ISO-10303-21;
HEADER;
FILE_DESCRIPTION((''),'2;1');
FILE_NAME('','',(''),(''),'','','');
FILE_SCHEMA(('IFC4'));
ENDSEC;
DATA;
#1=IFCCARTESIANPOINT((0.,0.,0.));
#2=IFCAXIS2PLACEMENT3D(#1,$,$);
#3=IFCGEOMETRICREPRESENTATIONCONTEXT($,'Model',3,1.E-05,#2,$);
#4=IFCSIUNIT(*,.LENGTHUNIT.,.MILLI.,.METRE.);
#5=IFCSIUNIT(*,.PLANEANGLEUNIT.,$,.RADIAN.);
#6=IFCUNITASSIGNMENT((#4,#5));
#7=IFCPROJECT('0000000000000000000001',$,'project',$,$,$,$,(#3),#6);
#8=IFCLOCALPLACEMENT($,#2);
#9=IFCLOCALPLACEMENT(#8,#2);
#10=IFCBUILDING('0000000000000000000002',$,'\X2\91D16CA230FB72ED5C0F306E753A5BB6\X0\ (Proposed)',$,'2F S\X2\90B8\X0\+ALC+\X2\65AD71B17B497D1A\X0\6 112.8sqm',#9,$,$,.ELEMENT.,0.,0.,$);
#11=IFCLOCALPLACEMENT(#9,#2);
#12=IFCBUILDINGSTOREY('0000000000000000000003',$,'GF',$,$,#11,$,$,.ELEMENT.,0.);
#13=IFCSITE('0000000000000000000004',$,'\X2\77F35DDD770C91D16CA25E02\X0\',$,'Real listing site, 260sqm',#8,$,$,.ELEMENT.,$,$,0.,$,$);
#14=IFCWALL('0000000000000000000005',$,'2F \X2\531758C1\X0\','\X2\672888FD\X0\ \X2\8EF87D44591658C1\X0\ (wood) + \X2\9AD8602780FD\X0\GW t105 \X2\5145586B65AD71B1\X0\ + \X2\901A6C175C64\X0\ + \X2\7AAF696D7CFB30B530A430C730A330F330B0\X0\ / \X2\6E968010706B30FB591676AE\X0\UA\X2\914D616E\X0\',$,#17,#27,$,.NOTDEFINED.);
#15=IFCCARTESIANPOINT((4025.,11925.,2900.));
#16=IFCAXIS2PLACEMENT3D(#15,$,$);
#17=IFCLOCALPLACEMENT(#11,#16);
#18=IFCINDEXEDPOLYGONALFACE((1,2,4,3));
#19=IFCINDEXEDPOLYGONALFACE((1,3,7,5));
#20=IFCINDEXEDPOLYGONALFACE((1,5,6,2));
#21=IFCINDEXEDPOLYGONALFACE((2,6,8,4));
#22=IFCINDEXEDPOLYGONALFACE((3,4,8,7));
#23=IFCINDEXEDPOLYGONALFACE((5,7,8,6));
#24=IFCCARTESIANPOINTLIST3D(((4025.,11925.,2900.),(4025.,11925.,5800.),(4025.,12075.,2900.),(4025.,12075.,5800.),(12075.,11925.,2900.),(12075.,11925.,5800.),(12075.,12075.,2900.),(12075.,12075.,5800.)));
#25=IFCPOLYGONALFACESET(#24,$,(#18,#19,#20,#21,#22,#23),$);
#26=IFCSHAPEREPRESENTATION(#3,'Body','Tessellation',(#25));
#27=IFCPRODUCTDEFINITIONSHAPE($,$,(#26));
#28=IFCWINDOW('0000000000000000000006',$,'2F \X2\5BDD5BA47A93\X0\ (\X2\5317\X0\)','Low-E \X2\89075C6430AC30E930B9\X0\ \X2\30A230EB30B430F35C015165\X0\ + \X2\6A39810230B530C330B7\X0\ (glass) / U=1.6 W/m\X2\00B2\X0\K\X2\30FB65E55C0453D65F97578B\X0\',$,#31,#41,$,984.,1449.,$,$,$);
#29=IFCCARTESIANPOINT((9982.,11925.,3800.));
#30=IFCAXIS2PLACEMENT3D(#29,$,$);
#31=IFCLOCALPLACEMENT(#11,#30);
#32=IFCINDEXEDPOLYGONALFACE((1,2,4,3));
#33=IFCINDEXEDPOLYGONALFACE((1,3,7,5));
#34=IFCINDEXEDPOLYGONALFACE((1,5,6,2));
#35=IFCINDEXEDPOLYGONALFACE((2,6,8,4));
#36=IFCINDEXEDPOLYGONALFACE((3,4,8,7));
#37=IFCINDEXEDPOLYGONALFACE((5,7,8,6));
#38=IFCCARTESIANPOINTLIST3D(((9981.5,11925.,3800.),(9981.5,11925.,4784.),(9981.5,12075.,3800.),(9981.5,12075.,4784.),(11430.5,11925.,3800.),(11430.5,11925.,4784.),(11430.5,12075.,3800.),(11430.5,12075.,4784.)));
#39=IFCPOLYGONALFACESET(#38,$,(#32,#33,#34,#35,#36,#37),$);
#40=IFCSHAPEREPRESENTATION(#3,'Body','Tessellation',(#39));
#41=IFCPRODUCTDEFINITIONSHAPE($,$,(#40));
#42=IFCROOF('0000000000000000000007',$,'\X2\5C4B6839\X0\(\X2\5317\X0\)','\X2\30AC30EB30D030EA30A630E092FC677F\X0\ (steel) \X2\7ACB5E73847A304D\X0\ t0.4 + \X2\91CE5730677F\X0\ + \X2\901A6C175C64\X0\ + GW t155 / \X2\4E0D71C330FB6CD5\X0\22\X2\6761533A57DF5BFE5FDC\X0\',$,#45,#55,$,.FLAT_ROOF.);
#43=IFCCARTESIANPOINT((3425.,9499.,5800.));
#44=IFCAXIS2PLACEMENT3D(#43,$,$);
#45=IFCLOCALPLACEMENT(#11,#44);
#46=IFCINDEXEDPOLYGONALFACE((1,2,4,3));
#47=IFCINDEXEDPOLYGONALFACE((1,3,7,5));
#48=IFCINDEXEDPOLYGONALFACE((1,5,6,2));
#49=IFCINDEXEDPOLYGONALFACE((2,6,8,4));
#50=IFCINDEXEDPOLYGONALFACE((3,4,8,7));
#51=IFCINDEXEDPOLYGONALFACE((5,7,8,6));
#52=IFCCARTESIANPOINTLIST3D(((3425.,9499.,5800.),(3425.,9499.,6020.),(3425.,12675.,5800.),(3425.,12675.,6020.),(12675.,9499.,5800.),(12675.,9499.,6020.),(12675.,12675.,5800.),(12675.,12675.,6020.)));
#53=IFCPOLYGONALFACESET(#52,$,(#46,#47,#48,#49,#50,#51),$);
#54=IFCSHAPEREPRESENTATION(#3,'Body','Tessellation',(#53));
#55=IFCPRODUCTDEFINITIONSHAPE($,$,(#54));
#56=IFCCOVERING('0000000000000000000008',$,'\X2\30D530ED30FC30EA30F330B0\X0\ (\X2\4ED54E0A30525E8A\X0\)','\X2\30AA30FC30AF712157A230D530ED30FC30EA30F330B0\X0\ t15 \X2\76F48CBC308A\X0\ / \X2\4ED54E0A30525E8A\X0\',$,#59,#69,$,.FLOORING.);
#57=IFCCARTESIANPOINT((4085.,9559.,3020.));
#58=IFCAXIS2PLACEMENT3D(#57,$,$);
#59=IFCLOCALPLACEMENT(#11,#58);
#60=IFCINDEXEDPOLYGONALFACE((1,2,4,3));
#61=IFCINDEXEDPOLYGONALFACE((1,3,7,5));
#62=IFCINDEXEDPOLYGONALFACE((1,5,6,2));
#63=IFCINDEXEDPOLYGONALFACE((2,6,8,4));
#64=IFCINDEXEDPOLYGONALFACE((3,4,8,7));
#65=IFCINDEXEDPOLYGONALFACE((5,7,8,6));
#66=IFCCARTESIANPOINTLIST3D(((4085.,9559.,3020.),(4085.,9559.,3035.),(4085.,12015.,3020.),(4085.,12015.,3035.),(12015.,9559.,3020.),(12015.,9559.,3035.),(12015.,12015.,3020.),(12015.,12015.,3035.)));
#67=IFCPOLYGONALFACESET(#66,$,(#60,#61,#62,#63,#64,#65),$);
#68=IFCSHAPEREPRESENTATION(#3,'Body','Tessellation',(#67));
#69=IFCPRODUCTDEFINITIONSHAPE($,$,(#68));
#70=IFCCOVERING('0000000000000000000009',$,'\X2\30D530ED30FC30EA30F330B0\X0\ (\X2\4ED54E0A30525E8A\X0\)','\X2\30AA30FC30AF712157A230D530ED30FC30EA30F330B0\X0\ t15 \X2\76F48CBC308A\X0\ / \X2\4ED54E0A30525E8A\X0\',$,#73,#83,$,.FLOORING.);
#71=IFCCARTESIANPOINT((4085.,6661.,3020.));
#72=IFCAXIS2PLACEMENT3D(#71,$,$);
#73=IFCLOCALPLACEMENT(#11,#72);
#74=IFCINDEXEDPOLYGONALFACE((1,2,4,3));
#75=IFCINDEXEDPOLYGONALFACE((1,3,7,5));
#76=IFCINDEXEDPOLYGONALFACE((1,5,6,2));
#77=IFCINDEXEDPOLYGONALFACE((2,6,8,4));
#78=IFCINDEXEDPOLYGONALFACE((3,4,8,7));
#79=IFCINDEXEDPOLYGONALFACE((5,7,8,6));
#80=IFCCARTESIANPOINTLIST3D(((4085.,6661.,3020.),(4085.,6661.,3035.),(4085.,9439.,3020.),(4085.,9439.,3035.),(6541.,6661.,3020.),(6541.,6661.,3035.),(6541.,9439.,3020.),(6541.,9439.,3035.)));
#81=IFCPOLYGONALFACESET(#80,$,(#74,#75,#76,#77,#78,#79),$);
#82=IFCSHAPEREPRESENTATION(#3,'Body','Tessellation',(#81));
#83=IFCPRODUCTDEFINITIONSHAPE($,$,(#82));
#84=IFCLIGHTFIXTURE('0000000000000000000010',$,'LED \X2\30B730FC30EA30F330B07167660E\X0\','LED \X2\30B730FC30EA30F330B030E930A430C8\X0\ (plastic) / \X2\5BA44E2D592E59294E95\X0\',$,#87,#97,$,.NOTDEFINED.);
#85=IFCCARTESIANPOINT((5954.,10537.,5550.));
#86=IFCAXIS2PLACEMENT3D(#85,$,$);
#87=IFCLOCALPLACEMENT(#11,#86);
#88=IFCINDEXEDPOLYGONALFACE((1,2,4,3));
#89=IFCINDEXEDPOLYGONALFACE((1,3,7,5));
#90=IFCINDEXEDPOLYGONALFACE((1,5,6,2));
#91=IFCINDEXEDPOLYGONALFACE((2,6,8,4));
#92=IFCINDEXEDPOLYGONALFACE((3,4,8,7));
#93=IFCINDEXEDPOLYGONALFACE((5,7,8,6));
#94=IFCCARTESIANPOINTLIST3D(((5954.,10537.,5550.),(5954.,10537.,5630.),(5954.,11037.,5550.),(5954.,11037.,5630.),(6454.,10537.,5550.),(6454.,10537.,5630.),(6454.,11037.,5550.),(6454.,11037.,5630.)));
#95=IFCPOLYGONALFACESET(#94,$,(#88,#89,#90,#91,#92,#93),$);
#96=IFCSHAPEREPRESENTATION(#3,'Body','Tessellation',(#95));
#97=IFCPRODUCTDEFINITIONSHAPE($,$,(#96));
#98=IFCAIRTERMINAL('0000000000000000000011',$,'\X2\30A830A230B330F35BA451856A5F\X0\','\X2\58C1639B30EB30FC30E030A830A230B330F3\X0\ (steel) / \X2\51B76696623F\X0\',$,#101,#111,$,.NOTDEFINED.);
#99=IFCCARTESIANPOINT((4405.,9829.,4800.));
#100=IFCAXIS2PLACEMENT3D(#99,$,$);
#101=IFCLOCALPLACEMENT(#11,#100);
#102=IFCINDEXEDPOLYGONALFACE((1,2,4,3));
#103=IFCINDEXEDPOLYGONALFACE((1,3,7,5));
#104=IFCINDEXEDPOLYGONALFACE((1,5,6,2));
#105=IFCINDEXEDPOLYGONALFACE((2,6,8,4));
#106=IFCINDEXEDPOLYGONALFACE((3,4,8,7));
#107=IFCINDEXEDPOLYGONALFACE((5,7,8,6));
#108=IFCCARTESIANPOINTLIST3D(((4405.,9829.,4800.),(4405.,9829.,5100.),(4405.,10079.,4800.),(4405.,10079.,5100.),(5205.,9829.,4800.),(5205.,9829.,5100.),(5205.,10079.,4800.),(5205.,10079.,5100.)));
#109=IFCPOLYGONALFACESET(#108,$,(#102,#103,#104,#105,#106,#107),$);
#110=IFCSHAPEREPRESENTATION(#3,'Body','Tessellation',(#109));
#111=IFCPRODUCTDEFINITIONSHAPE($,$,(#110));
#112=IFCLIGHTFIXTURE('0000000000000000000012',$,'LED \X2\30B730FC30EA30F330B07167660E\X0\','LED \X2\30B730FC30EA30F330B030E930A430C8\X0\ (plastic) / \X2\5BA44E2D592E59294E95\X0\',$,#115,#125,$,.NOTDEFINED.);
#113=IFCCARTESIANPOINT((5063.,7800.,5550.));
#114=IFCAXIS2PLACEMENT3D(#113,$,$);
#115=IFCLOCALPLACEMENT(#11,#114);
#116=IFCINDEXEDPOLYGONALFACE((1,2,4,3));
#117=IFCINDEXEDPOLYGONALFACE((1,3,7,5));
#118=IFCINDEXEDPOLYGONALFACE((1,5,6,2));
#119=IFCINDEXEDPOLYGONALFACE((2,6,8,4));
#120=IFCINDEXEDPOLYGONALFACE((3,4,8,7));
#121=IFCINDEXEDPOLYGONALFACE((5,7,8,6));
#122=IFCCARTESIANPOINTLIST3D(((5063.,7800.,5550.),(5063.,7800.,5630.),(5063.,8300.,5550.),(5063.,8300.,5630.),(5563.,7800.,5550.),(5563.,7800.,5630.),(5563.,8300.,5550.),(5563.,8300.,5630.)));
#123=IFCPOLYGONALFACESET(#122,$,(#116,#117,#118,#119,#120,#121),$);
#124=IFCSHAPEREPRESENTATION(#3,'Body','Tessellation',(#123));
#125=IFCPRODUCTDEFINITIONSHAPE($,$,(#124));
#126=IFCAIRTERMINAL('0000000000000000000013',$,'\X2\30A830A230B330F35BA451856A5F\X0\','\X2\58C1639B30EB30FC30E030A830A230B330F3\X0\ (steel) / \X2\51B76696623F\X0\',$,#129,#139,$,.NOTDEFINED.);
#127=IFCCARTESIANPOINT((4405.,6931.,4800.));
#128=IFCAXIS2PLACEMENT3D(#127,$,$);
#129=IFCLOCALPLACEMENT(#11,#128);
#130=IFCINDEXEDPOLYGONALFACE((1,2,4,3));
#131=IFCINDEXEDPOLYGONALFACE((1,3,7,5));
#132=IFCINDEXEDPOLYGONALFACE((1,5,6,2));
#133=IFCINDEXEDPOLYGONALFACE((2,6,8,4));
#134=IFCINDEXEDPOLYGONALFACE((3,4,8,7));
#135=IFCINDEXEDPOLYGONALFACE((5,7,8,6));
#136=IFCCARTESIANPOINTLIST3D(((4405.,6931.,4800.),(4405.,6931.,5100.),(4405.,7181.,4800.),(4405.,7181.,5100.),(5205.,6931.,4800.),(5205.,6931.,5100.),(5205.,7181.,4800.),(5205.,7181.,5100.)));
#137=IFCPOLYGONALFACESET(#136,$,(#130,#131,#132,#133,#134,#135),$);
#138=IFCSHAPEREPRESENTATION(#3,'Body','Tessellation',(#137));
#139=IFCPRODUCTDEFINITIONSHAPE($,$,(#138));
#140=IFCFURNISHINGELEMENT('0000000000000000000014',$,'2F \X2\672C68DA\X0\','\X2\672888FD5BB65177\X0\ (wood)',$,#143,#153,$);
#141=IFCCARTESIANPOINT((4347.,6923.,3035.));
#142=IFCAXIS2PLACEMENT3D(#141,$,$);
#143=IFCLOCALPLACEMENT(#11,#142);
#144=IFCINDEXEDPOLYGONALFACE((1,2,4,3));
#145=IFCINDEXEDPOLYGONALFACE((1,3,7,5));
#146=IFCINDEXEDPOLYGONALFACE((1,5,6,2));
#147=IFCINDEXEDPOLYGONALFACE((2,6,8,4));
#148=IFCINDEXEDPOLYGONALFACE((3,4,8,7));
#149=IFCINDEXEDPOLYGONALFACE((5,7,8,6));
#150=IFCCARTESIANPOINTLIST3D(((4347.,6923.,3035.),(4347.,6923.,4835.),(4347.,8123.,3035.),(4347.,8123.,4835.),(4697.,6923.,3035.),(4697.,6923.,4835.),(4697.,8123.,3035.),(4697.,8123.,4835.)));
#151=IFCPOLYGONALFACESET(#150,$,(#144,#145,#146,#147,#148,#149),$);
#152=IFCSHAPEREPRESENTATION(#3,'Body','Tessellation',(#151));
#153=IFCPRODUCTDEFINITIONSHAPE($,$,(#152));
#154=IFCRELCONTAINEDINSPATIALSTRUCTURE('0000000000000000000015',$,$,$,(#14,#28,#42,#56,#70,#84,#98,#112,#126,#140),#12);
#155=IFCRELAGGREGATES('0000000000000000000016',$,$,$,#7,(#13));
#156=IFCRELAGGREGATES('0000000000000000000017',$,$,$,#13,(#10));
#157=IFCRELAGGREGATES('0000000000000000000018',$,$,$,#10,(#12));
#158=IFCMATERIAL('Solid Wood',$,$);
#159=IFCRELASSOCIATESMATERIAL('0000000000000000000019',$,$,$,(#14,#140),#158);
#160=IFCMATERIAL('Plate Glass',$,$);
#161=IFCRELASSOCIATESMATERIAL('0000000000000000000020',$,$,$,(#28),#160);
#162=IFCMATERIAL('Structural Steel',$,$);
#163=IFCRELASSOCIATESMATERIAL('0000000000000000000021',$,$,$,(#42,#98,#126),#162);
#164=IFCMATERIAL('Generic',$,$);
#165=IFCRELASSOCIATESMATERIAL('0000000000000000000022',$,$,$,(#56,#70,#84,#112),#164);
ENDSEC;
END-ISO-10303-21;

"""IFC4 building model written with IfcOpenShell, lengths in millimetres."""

from ifc_helpers import new_model, si_unit, frame, frame_2d, origin, place, context, project, spatial, rectangle, extrude, material, element, fill, save


model = new_model("IFC4")

# Units and contexts
model_context = context("Model", 3, precision=1e-05, world=origin())
ifc_project = project(units=[si_unit("LENGTHUNIT", "METRE", prefix="MILLI"), si_unit("PLANEANGLEUNIT", "RADIAN")], contexts=[model_context])

# Site, building, storey
site_placement = place(None, origin())
site = spatial("IfcSite", under=ifc_project, at=site_placement, Name="石川県金沢市", ObjectType="Real listing site, 260sqm", CompositionType="ELEMENT", RefElevation=0.0)
building_placement = place(site_placement, origin())
building = spatial("IfcBuilding", under=site, at=building_placement, Name="金沢・狭小の町家 (Proposed)", ObjectType="2F S邸+ALC+断熱等級6 112.8sqm", CompositionType="ELEMENT", ElevationOfRefHeight=0.0, ElevationOfTerrain=0.0)
storey_placement = place(building_placement, origin())
storey = spatial("IfcBuildingStorey", under=building, at=storey_placement, Name="GF", CompositionType="ELEMENT", Elevation=0.0)

# Shared definitions
ifc_material_1 = material(Name="Solid Wood")

# Wall, opening, window
wall_placement = place(storey_placement, frame((4025.0, 11925.0, 2900.0)))
wall = element("IfcWall", 1, at=wall_placement, inside=storey, material=ifc_material_1, Name="2F 北壁", Description="木製 軸組外壁 (wood) + 高性能GW t105 充填断熱 + 通気層 + 窯業系サイディング / 準耐火・外皮UA配慮", PredefinedType="NOTDEFINED", context=model_context, shape_type="SweptSolid", body=[
    extrude(rectangle(XDim=8050.0, YDim=150.0, at=frame_2d((4025.0, 75.0))), frame((4025.0, 11925.0, 2900.0)), (0.0, 0.0, 1.0), 2900.0),
])
opening_placement = place(storey_placement, frame((9982.0, 11925.0, 3800.0)))
opening = element("IfcOpeningElement", 2, at=opening_placement, cuts=wall, PredefinedType="NOTDEFINED", context=model_context, shape_type="SweptSolid", body=[
    extrude(rectangle(XDim=1449.0, YDim=150.0, at=frame_2d((724.0, 75.0))), frame((9982.0, 11925.0, 3800.0)), (0.0, 0.0, 1.0), 984.0),
])
ifc_material_2 = material(Name="Plate Glass")
window_placement = place(storey_placement, frame((9982.0, 11925.0, 3800.0)))
window = element("IfcWindow", 3, at=window_placement, inside=storey, material=ifc_material_2, Name="2F 寝室窓 (北)", Description="Low-E 複層ガラス アルゴン封入 + 樹脂サッシ (glass) / U=1.6 W/m²K・日射取得型", OverallHeight=984.0, OverallWidth=1449.0, context=model_context, shape_type="SweptSolid", body=[
    extrude(rectangle(XDim=1449.0, YDim=150.0, at=frame_2d((724.0, 75.0))), frame((9982.0, 11925.0, 3800.0)), (0.0, 0.0, 1.0), 984.0),
])
fill(opening, window)

# Roof
ifc_material_3 = material(Name="Structural Steel")
for number, where, name in (
    (4, (3425.0, 9499.0, 5800.0), "屋根(北)"),
):
    element("IfcRoof", number, at=place(storey_placement, frame(where)), inside=storey, material=ifc_material_3, Name=name, Description="ガルバリウム鋼板 (steel) 立平葺き t0.4 + 野地板 + 通気層 + GW t155 / 不燃・法22条区域対応", PredefinedType="FLAT_ROOF", context=model_context, shape_type="SweptSolid", body=[
        extrude(rectangle(XDim=9250.0, YDim=3176.0, at=frame_2d((4625.0, 1588.0))), frame((3425.0, 9499.0, 5800.0)), (0.0, 0.0, 1.0), 220.0),
    ])

# Coverings
ifc_material_4 = material(Name="Generic")
covering_1_placement = place(storey_placement, frame((4085.0, 9559.0, 3020.0)))
element("IfcCovering", 5, at=covering_1_placement, inside=storey, material=ifc_material_4, Name="フローリング (仕上げ床)", Description="オーク無垢フローリング t15 直貼り / 仕上げ床", PredefinedType="FLOORING", context=model_context, shape_type="SweptSolid", body=[
    extrude(rectangle(XDim=7930.0, YDim=2456.0, at=frame_2d((3965.0, 1228.0))), frame((4085.0, 9559.0, 3020.0)), (0.0, 0.0, 1.0), 15.0),
])
covering_2_placement = place(storey_placement, frame((4085.0, 6661.0, 3020.0)))
element("IfcCovering", 6, at=covering_2_placement, inside=storey, material=ifc_material_4, Name="フローリング (仕上げ床)", Description="オーク無垢フローリング t15 直貼り / 仕上げ床", PredefinedType="FLOORING", context=model_context, shape_type="SweptSolid", body=[
    extrude(rectangle(XDim=2456.0, YDim=2778.0, at=frame_2d((1228.0, 1389.0))), frame((4085.0, 6661.0, 3020.0)), (0.0, 0.0, 1.0), 15.0),
])

# Light fixture
light_fixture_1_placement = place(storey_placement, frame((5954.0, 10537.0, 5550.0)))
element("IfcLightFixture", 7, at=light_fixture_1_placement, inside=storey, material=ifc_material_4, Name="LED シーリング照明", Description="LED シーリングライト (plastic) / 室中央天井", PredefinedType="NOTDEFINED", context=model_context, shape_type="SweptSolid", body=[
    extrude(rectangle(XDim=500.0, YDim=500.0, at=frame_2d((250.0, 250.0))), frame((5954.0, 10537.0, 5550.0)), (0.0, 0.0, 1.0), 80.0),
])

# Air terminal
air_terminal_1_placement = place(storey_placement, frame((4405.0, 9829.0, 4800.0)))
element("IfcAirTerminal", 8, at=air_terminal_1_placement, inside=storey, material=ifc_material_3, Name="エアコン室内機", Description="壁掛ルームエアコン (steel) / 冷暖房", PredefinedType="NOTDEFINED", context=model_context, shape_type="SweptSolid", body=[
    extrude(rectangle(XDim=800.0, YDim=250.0, at=frame_2d((400.0, 125.0))), frame((4405.0, 9829.0, 4800.0)), (0.0, 0.0, 1.0), 300.0),
])

# Light fixture
light_fixture_2_placement = place(storey_placement, frame((5063.0, 7800.0, 5550.0)))
element("IfcLightFixture", 9, at=light_fixture_2_placement, inside=storey, material=ifc_material_4, Name="LED シーリング照明", Description="LED シーリングライト (plastic) / 室中央天井", PredefinedType="NOTDEFINED", context=model_context, shape_type="SweptSolid", body=[
    extrude(rectangle(XDim=500.0, YDim=500.0, at=frame_2d((250.0, 250.0))), frame((5063.0, 7800.0, 5550.0)), (0.0, 0.0, 1.0), 80.0),
])

# Air terminal
air_terminal_2_placement = place(storey_placement, frame((4405.0, 6931.0, 4800.0)))
element("IfcAirTerminal", 10, at=air_terminal_2_placement, inside=storey, material=ifc_material_3, Name="エアコン室内機", Description="壁掛ルームエアコン (steel) / 冷暖房", PredefinedType="NOTDEFINED", context=model_context, shape_type="SweptSolid", body=[
    extrude(rectangle(XDim=800.0, YDim=250.0, at=frame_2d((400.0, 125.0))), frame((4405.0, 6931.0, 4800.0)), (0.0, 0.0, 1.0), 300.0),
])

# Furnishing element
furnishing_placement = place(storey_placement, frame((4347.0, 6923.0, 3035.0)))
element("IfcFurnishingElement", 11, at=furnishing_placement, inside=storey, material=ifc_material_1, Name="2F 本棚", Description="木製家具 (wood)", context=model_context, shape_type="SweptSolid", body=[
    extrude(rectangle(XDim=350.0, YDim=1200.0, at=frame_2d((175.0, 600.0))), frame((4347.0, 6923.0, 3035.0)), (0.0, 0.0, 1.0), 1800.0),
])

save(model, "model.ifc")
